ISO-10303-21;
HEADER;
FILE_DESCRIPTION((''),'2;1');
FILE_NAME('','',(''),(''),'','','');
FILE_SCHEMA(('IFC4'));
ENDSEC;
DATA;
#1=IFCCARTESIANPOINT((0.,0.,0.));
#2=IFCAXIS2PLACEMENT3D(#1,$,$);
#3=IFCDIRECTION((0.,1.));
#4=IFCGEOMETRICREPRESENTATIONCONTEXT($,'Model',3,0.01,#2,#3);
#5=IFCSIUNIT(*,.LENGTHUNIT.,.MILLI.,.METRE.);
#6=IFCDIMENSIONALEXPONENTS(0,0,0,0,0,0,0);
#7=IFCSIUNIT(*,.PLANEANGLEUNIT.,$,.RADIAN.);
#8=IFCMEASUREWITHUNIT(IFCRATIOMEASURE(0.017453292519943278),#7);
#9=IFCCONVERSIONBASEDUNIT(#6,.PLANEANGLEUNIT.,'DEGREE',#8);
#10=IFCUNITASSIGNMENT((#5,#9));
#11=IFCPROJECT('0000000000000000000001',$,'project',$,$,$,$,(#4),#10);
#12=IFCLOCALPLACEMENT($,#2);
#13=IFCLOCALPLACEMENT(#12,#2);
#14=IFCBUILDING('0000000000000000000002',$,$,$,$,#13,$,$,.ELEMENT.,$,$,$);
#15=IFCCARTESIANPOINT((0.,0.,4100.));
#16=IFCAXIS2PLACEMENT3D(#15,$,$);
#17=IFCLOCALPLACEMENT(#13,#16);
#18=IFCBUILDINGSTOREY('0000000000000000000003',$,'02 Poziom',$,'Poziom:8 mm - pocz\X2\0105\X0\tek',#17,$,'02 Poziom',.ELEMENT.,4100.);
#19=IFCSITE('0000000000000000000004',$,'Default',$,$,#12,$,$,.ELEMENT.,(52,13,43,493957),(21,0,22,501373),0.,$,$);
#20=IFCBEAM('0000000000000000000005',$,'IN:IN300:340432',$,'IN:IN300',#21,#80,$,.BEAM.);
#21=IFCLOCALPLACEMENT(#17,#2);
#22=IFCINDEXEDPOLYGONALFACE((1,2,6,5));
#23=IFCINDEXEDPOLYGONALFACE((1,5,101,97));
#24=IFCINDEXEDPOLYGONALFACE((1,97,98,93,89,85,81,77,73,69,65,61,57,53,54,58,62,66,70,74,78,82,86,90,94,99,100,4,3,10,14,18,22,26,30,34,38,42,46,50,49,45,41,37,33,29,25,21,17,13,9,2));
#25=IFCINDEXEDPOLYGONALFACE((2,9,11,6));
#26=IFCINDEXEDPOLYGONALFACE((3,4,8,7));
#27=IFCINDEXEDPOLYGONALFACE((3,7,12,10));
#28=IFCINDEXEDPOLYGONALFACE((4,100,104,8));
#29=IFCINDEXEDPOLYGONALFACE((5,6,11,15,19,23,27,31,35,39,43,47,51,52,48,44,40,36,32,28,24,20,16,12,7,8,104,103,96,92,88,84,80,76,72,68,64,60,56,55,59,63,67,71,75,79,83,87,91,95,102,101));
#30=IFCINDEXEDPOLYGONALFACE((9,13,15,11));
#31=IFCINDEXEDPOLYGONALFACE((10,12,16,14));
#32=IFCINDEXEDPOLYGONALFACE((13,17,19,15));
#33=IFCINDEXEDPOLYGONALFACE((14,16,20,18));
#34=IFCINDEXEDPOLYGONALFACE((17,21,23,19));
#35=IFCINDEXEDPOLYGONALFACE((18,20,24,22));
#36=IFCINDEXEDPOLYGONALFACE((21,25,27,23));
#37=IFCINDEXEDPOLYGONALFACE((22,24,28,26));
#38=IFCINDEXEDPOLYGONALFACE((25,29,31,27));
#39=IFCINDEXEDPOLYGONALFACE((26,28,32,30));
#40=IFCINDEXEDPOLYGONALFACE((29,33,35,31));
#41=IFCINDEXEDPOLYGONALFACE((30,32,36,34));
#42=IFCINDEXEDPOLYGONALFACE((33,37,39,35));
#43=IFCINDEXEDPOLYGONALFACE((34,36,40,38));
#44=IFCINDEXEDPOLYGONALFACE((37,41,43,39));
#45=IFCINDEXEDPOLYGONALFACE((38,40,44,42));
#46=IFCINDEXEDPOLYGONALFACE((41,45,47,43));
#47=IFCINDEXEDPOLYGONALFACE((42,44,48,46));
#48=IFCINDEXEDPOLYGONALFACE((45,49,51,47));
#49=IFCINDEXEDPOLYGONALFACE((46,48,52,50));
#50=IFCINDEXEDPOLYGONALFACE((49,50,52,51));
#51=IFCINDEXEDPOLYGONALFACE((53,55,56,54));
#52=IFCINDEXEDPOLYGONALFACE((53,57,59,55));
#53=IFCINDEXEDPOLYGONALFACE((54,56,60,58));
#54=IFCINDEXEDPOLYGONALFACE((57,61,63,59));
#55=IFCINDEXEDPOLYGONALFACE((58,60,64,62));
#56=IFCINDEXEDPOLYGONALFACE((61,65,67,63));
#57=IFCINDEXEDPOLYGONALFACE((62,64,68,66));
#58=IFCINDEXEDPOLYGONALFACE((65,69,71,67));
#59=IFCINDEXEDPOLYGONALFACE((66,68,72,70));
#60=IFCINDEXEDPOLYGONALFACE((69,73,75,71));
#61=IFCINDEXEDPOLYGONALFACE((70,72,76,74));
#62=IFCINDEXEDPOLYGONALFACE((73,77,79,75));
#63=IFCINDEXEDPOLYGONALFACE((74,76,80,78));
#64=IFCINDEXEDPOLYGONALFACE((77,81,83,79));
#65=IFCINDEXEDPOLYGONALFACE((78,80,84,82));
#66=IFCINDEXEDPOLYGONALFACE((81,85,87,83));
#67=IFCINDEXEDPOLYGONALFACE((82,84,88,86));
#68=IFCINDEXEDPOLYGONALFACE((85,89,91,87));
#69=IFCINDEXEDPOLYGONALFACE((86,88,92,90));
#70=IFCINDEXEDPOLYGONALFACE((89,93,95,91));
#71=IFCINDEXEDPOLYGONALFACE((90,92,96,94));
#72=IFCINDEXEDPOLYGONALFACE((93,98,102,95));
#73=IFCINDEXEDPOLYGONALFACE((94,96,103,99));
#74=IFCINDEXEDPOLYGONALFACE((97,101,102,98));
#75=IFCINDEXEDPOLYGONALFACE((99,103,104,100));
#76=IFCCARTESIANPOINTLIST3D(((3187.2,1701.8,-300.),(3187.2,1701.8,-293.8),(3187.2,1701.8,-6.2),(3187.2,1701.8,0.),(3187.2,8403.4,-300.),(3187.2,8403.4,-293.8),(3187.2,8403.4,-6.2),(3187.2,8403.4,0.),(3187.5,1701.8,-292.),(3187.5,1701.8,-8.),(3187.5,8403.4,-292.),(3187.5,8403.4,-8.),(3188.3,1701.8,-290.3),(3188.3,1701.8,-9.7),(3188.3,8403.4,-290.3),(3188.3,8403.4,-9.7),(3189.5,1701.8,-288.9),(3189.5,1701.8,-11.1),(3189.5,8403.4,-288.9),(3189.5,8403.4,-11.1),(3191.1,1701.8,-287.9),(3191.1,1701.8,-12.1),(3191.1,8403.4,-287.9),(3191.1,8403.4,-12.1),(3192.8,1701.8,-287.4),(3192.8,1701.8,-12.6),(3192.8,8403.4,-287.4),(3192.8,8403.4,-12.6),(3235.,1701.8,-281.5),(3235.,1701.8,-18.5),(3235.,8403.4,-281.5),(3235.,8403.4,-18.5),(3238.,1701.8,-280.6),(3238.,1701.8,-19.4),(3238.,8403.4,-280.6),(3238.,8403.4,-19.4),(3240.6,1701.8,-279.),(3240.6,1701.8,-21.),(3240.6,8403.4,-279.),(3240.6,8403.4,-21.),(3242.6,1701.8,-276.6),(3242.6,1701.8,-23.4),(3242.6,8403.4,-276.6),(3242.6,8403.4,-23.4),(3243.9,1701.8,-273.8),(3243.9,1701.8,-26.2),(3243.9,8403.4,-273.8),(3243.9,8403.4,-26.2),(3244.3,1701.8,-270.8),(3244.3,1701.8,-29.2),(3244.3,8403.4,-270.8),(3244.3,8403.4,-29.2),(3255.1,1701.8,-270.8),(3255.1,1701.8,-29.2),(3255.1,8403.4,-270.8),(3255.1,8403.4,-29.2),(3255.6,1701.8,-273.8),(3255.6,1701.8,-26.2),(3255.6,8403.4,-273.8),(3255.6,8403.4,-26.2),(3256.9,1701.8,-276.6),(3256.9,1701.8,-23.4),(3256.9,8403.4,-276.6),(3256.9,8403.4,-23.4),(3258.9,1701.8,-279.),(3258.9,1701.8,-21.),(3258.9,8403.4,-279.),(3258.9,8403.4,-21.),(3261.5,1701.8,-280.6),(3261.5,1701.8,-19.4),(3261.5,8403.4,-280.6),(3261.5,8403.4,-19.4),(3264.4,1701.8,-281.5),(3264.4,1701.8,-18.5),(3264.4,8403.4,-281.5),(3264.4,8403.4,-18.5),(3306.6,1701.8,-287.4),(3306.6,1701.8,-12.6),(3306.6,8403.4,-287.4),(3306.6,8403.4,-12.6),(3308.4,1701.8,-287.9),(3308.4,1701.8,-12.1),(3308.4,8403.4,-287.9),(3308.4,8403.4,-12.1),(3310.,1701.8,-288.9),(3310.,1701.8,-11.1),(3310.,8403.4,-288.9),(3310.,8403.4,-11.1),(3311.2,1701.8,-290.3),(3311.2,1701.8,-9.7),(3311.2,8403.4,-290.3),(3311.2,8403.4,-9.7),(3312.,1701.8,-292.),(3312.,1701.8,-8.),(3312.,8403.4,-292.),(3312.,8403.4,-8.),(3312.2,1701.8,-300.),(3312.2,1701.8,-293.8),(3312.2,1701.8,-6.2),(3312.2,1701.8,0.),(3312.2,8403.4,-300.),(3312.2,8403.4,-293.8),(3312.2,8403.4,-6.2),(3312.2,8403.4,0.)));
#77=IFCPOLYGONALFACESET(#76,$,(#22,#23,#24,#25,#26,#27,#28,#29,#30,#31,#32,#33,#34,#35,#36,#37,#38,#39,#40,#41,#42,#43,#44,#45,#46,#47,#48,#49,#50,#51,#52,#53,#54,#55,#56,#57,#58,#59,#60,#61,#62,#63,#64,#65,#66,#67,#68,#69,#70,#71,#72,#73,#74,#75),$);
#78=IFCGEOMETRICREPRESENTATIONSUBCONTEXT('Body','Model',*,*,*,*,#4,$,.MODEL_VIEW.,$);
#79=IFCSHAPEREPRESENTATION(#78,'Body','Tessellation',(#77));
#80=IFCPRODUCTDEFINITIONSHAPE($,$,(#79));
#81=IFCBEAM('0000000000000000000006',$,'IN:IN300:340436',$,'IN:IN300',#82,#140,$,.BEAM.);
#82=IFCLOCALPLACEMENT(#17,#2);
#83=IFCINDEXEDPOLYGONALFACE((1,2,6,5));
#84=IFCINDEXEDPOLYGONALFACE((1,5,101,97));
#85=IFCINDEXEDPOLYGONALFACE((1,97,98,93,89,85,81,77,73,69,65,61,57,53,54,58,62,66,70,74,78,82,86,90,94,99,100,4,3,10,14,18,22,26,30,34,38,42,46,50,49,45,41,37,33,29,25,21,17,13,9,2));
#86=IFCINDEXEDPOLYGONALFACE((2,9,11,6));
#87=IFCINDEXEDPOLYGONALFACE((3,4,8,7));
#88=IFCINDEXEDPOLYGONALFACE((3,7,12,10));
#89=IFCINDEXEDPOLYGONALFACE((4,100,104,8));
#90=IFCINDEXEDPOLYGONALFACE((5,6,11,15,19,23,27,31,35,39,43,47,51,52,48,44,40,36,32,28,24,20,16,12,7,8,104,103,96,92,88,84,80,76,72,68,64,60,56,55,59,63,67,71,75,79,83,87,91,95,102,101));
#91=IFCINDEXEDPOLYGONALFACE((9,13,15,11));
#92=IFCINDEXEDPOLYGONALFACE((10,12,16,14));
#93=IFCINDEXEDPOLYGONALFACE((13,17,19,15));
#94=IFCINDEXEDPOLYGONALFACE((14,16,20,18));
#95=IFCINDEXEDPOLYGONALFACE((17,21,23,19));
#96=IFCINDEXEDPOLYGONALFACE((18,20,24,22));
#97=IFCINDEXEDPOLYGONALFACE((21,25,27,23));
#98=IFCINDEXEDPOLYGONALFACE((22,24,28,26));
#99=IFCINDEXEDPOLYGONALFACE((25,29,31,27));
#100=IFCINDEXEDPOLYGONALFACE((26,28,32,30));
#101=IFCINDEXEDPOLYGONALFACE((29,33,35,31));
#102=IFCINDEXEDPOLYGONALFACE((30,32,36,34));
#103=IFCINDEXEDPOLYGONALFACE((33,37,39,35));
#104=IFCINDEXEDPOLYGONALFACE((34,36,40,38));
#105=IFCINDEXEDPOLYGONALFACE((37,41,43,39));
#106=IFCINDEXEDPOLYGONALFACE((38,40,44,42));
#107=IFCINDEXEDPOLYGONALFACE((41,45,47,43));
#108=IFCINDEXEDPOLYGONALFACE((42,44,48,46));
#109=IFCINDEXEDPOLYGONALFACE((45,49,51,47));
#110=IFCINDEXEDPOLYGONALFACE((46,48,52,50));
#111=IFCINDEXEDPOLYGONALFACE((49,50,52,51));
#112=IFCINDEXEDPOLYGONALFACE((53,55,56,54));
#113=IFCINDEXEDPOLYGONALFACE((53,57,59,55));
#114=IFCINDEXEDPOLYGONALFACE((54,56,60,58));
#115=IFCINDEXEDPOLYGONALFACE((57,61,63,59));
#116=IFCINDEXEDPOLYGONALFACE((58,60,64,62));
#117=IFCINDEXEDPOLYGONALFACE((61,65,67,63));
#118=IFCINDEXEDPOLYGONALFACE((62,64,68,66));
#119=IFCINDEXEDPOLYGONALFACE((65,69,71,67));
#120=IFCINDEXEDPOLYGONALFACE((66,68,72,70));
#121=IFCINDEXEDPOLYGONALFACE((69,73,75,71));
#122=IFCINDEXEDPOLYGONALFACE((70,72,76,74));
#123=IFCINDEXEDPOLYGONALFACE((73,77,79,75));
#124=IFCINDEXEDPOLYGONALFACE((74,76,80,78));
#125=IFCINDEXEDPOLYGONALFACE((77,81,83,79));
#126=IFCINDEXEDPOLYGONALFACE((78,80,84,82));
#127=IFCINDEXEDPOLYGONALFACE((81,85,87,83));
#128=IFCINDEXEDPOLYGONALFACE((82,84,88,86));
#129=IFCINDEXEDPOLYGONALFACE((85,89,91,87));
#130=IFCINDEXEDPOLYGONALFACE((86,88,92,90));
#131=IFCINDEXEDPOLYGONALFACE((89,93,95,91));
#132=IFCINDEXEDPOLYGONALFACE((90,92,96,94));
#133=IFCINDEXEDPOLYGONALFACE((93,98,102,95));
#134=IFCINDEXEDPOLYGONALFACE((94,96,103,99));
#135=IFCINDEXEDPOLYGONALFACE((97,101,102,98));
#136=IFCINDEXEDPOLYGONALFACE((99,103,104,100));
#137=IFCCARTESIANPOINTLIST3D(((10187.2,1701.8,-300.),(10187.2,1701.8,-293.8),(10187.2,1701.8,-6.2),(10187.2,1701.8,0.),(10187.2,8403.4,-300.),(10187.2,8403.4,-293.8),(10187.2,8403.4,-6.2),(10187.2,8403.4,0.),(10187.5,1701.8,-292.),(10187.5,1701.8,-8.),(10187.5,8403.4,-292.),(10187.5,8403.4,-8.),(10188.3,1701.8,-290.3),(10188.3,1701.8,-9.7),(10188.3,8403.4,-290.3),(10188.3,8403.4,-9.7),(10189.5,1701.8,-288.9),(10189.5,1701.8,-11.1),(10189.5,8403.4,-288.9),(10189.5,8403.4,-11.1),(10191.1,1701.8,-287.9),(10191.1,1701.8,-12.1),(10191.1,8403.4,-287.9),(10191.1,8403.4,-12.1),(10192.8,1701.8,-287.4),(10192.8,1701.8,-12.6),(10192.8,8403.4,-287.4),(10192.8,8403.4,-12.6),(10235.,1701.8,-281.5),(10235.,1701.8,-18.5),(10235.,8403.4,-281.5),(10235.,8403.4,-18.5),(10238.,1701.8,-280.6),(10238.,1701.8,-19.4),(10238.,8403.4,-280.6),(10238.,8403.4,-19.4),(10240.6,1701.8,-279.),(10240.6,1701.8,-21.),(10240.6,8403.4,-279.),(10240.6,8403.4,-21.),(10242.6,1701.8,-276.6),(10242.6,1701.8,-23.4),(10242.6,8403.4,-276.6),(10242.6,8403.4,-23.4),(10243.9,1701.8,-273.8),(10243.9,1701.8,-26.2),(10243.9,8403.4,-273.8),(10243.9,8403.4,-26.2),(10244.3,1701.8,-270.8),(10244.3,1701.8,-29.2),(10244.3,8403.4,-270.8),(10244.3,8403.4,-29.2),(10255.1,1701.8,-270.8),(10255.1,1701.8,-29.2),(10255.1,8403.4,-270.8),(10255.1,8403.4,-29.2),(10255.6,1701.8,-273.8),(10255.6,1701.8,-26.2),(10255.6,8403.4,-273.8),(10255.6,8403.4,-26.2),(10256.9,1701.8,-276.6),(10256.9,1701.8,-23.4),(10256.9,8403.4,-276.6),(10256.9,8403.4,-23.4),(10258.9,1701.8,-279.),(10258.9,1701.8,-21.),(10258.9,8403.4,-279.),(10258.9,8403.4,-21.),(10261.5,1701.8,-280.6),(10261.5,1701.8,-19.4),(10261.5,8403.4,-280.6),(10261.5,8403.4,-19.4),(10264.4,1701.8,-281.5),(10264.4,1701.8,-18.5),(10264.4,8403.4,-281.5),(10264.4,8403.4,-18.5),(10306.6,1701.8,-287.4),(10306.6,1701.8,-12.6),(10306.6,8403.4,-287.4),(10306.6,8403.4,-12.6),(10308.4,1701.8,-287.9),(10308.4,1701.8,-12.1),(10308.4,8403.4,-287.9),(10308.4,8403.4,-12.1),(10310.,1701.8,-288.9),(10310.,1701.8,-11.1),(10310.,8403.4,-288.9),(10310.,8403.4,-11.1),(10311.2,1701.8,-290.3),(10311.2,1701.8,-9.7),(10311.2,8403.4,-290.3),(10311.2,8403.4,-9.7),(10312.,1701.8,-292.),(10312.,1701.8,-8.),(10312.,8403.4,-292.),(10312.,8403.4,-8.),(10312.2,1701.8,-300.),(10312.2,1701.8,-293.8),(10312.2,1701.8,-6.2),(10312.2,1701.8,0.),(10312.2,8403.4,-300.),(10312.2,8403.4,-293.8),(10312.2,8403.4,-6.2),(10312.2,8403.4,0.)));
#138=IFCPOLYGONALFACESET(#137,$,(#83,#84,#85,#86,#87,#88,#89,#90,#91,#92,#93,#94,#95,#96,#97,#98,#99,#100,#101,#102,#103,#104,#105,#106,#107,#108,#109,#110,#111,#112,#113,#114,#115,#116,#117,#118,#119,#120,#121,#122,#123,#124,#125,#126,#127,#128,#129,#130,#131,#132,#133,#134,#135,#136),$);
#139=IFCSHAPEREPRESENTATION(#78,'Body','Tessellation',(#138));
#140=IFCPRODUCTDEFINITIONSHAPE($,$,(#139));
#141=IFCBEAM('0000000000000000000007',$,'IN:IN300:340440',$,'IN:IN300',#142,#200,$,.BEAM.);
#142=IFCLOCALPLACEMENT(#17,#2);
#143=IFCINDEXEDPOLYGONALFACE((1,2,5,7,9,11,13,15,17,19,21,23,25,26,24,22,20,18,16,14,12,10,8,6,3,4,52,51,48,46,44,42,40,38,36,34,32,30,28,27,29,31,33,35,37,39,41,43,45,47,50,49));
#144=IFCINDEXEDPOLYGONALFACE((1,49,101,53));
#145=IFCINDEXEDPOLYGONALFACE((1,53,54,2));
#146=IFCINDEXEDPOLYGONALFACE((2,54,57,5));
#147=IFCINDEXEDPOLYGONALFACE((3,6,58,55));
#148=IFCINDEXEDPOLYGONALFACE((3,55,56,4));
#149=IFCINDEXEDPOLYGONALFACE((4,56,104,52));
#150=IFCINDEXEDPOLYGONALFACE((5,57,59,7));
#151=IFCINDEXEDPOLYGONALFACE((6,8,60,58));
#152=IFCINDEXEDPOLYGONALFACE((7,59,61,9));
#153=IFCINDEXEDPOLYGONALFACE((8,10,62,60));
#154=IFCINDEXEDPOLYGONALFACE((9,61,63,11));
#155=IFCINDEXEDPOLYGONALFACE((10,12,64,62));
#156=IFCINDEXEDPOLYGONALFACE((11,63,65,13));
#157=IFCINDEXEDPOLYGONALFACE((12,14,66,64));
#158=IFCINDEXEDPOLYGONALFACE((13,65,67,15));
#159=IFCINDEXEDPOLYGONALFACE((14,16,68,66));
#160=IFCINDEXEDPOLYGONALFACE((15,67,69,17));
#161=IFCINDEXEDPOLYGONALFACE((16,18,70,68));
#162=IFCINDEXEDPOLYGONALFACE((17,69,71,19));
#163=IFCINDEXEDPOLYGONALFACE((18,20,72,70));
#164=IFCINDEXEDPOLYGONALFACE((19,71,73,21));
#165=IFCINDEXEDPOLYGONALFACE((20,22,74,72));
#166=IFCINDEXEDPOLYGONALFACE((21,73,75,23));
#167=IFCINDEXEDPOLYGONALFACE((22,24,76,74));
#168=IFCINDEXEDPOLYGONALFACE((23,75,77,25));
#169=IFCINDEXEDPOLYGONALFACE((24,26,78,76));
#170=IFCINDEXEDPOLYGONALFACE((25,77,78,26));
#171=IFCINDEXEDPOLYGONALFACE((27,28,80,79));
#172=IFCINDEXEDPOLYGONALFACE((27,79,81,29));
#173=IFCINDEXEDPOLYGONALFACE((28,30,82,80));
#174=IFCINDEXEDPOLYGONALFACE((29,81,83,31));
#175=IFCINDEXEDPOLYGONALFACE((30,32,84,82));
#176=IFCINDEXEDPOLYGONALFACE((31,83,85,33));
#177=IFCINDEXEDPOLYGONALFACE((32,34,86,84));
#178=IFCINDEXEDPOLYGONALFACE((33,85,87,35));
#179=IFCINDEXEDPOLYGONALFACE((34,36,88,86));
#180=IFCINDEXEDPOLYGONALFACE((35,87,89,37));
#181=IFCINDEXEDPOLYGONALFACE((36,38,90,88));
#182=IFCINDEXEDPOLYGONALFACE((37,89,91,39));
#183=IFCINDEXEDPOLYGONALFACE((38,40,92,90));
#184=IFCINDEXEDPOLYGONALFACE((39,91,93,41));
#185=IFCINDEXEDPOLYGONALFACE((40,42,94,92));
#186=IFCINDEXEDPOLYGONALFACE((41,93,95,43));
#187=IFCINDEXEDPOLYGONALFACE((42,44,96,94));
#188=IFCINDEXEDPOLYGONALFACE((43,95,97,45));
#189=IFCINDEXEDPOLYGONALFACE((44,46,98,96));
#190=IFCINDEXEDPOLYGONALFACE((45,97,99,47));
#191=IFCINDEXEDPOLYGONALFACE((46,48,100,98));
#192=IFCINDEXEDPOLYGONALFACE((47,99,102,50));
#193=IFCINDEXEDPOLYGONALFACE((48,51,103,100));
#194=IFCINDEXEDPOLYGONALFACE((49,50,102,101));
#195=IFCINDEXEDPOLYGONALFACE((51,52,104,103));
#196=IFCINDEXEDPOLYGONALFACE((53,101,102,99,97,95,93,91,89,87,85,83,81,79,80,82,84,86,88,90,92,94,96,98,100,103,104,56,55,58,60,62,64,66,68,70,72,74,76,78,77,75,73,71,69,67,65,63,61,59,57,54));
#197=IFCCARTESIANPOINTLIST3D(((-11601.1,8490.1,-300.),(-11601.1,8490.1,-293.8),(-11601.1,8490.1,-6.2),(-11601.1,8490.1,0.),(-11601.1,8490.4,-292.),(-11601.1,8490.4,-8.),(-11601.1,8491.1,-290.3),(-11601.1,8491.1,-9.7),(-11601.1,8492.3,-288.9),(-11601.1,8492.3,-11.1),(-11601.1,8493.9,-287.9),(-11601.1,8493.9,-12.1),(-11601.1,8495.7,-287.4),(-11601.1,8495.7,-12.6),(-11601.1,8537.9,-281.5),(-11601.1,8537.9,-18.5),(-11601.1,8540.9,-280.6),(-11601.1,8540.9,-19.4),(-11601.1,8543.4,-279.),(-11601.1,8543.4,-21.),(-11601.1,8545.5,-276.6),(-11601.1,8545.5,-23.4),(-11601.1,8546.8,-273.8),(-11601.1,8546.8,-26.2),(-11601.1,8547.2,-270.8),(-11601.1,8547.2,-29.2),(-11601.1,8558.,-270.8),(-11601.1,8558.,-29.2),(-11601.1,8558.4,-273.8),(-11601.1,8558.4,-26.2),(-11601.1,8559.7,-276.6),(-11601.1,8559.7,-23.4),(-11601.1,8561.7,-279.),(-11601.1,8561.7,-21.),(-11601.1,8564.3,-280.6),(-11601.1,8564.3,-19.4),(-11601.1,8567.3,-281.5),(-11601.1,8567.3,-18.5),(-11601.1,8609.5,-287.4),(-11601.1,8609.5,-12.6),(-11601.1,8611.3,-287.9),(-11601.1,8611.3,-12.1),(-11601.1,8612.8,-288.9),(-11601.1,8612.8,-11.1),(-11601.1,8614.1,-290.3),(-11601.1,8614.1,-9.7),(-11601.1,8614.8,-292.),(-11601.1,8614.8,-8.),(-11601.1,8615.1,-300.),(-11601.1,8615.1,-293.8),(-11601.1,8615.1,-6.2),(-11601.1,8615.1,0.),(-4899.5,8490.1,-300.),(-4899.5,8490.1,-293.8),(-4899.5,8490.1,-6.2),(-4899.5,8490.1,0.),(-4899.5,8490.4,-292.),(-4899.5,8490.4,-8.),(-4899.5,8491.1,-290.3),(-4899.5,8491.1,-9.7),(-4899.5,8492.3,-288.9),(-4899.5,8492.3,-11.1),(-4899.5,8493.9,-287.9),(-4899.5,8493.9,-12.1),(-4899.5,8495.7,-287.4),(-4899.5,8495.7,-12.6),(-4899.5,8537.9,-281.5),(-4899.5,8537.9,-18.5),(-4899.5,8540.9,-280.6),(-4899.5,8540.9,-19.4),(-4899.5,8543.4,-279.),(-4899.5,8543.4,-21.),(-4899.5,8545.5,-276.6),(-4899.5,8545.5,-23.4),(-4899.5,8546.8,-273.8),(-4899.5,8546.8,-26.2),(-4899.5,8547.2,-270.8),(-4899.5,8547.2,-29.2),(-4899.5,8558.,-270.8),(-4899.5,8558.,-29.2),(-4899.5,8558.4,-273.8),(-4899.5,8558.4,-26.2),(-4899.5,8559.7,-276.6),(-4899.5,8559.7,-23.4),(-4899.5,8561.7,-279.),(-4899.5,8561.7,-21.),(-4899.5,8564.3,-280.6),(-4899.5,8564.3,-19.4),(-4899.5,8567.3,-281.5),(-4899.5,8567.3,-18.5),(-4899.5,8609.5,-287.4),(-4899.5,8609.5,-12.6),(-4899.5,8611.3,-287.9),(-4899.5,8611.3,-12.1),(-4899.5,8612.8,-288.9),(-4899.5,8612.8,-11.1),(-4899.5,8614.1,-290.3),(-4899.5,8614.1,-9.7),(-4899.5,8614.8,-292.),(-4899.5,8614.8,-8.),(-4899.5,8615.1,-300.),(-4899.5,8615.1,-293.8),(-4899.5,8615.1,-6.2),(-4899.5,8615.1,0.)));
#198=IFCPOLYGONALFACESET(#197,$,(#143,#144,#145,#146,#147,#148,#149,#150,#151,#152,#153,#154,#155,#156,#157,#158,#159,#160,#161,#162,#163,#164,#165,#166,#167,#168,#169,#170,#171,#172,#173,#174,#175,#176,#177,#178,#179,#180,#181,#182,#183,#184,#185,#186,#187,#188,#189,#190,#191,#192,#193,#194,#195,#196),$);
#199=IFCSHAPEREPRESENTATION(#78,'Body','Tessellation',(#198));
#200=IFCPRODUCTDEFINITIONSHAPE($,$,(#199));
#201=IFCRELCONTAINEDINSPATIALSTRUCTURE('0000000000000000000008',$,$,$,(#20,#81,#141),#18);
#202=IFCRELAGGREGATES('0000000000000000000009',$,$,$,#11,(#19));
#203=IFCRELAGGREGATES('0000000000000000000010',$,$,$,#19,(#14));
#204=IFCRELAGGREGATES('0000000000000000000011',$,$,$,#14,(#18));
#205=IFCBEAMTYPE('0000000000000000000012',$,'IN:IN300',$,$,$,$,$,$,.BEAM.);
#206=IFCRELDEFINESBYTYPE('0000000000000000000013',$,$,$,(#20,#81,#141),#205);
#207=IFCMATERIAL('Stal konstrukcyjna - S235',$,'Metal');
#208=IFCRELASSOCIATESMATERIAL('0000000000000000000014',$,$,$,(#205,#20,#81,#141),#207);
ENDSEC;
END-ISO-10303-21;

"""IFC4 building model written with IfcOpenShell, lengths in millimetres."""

from ifc_helpers import new_model, entity, si_unit, converted_unit, direction, frame, origin, place, context, subcontext, project, spatial, line, arc, indexed_curve, outline, extrude, source, transform, mapped, material, type_object, type_shapes, element, save


model = new_model("IFC4")

# Units and contexts
model_context = context("Model", 3, precision=0.01, world=origin(), true_north=direction((0.0, 1.0)))
body_context = subcontext(model_context, "Body", "Model", "MODEL_VIEW")
ifc_project = project(units=[si_unit("LENGTHUNIT", "METRE", prefix="MILLI"), converted_unit("PLANEANGLEUNIT", "DEGREE", entity("IfcRatioMeasure", 0.017453292519943278), si_unit("PLANEANGLEUNIT", "RADIAN"), dimensions=[0, 0, 0, 0, 0, 0, 0])], contexts=[model_context])

# Site, building, storey
site_placement = place(None, origin())
site = spatial("IfcSite", under=ifc_project, at=site_placement, Name="Default", CompositionType="ELEMENT", RefLatitude=(52, 13, 43, 493957), RefLongitude=(21, 0, 22, 501373), RefElevation=0.0)
building_placement = place(site_placement, origin())
building = spatial("IfcBuilding", under=site, at=building_placement, CompositionType="ELEMENT")
storey_placement = place(building_placement, frame((0.0, 0.0, 4100.0)))
storey = spatial("IfcBuildingStorey", under=building, at=storey_placement, Name="02 Poziom", ObjectType="Poziom:8 mm - początek", LongName="02 Poziom", CompositionType="ELEMENT", Elevation=4100.0)

# Shared definitions
ifc_material_1 = material(Name="Stal konstrukcyjna - S235", Category="Metal")

# Beams
beam_type_1 = type_object("IfcBeamType", Name="IN:IN300", PredefinedType="BEAM", material=ifc_material_1)
shared_shape_1 = source(origin(), body_context, "Body", "SweptSolid", [
    extrude(outline(indexed_curve([(143.8, -62.5), (150.0, -62.5), (150.0, 62.5), (143.8, 62.5), (139.6, 60.9), (137.4, 56.9), (131.5, 14.7), (127.9, 8.1), (120.8, 5.4), (-120.8, 5.4), (-127.9, 8.1), (-131.5, 14.7), (-137.4, 56.9), (-139.6, 60.9), (-143.8, 62.5), (-150.0, 62.5), (-150.0, -62.5), (-143.8, -62.5), (-139.6, -60.9), (-137.4, -56.9), (-131.5, -14.7), (-127.9, -8.1), (-120.8, -5.4), (120.8, -5.4), (127.9, -8.1), (131.5, -14.7), (137.4, -56.9), (139.6, -60.9)], segments=[line(1, 2, 3, 4), arc(4, 5, 6), line(6, 7), arc(7, 8, 9), line(9, 10), arc(10, 11, 12), line(12, 13), arc(13, 14, 15), line(15, 16, 17, 18), arc(18, 19, 20), line(20, 21), arc(21, 22, 23), line(23, 24), arc(24, 25, 26), line(26, 27), arc(27, 28, 1)], self_intersect=False)), frame((-3350.8, 0.0, 0.0), z_axis=(1.0, 0.0, 0.0), x_axis=(0.0, 0.0, -1.0)), (0.0, 0.0, 1.0), 6701.6),
])
type_shapes(beam_type_1, [shared_shape_1])
for number, where, z_axis, x_axis, name in (
    (1, (3249.7, 5052.6, -150.0), (0.0, 0.0, 1.0), (0.0, -1.0, 0.0), "IN:IN300:340432"),
    (2, (10249.7, 5052.6, -150.0), (0.0, 0.0, 1.0), (0.0, -1.0, 0.0), "IN:IN300:340436"),
):
    element("IfcBeam", number, at=place(storey_placement, frame(where, z_axis=z_axis, x_axis=x_axis)), inside=storey, type_object=beam_type_1, material=ifc_material_1, Name=name, ObjectType="IN:IN300", PredefinedType="BEAM", context=body_context, shape_type="MappedRepresentation", body=[
        mapped(shared_shape_1, transform((0.0, 0.0, 0.0), scale=1.0)),
    ])
for number, where, name in (
    (3, (-8250.3, 8552.6, -150.0), "IN:IN300:340440"),
):
    element("IfcBeam", number, at=place(storey_placement, frame(where)), inside=storey, type_object=beam_type_1, material=ifc_material_1, Name=name, ObjectType="IN:IN300", PredefinedType="BEAM", context=body_context, shape_type="MappedRepresentation", body=[
        mapped(shared_shape_1, transform((0.0, 0.0, 0.0), scale=1.0)),
    ])

save(model, "model.ifc")
